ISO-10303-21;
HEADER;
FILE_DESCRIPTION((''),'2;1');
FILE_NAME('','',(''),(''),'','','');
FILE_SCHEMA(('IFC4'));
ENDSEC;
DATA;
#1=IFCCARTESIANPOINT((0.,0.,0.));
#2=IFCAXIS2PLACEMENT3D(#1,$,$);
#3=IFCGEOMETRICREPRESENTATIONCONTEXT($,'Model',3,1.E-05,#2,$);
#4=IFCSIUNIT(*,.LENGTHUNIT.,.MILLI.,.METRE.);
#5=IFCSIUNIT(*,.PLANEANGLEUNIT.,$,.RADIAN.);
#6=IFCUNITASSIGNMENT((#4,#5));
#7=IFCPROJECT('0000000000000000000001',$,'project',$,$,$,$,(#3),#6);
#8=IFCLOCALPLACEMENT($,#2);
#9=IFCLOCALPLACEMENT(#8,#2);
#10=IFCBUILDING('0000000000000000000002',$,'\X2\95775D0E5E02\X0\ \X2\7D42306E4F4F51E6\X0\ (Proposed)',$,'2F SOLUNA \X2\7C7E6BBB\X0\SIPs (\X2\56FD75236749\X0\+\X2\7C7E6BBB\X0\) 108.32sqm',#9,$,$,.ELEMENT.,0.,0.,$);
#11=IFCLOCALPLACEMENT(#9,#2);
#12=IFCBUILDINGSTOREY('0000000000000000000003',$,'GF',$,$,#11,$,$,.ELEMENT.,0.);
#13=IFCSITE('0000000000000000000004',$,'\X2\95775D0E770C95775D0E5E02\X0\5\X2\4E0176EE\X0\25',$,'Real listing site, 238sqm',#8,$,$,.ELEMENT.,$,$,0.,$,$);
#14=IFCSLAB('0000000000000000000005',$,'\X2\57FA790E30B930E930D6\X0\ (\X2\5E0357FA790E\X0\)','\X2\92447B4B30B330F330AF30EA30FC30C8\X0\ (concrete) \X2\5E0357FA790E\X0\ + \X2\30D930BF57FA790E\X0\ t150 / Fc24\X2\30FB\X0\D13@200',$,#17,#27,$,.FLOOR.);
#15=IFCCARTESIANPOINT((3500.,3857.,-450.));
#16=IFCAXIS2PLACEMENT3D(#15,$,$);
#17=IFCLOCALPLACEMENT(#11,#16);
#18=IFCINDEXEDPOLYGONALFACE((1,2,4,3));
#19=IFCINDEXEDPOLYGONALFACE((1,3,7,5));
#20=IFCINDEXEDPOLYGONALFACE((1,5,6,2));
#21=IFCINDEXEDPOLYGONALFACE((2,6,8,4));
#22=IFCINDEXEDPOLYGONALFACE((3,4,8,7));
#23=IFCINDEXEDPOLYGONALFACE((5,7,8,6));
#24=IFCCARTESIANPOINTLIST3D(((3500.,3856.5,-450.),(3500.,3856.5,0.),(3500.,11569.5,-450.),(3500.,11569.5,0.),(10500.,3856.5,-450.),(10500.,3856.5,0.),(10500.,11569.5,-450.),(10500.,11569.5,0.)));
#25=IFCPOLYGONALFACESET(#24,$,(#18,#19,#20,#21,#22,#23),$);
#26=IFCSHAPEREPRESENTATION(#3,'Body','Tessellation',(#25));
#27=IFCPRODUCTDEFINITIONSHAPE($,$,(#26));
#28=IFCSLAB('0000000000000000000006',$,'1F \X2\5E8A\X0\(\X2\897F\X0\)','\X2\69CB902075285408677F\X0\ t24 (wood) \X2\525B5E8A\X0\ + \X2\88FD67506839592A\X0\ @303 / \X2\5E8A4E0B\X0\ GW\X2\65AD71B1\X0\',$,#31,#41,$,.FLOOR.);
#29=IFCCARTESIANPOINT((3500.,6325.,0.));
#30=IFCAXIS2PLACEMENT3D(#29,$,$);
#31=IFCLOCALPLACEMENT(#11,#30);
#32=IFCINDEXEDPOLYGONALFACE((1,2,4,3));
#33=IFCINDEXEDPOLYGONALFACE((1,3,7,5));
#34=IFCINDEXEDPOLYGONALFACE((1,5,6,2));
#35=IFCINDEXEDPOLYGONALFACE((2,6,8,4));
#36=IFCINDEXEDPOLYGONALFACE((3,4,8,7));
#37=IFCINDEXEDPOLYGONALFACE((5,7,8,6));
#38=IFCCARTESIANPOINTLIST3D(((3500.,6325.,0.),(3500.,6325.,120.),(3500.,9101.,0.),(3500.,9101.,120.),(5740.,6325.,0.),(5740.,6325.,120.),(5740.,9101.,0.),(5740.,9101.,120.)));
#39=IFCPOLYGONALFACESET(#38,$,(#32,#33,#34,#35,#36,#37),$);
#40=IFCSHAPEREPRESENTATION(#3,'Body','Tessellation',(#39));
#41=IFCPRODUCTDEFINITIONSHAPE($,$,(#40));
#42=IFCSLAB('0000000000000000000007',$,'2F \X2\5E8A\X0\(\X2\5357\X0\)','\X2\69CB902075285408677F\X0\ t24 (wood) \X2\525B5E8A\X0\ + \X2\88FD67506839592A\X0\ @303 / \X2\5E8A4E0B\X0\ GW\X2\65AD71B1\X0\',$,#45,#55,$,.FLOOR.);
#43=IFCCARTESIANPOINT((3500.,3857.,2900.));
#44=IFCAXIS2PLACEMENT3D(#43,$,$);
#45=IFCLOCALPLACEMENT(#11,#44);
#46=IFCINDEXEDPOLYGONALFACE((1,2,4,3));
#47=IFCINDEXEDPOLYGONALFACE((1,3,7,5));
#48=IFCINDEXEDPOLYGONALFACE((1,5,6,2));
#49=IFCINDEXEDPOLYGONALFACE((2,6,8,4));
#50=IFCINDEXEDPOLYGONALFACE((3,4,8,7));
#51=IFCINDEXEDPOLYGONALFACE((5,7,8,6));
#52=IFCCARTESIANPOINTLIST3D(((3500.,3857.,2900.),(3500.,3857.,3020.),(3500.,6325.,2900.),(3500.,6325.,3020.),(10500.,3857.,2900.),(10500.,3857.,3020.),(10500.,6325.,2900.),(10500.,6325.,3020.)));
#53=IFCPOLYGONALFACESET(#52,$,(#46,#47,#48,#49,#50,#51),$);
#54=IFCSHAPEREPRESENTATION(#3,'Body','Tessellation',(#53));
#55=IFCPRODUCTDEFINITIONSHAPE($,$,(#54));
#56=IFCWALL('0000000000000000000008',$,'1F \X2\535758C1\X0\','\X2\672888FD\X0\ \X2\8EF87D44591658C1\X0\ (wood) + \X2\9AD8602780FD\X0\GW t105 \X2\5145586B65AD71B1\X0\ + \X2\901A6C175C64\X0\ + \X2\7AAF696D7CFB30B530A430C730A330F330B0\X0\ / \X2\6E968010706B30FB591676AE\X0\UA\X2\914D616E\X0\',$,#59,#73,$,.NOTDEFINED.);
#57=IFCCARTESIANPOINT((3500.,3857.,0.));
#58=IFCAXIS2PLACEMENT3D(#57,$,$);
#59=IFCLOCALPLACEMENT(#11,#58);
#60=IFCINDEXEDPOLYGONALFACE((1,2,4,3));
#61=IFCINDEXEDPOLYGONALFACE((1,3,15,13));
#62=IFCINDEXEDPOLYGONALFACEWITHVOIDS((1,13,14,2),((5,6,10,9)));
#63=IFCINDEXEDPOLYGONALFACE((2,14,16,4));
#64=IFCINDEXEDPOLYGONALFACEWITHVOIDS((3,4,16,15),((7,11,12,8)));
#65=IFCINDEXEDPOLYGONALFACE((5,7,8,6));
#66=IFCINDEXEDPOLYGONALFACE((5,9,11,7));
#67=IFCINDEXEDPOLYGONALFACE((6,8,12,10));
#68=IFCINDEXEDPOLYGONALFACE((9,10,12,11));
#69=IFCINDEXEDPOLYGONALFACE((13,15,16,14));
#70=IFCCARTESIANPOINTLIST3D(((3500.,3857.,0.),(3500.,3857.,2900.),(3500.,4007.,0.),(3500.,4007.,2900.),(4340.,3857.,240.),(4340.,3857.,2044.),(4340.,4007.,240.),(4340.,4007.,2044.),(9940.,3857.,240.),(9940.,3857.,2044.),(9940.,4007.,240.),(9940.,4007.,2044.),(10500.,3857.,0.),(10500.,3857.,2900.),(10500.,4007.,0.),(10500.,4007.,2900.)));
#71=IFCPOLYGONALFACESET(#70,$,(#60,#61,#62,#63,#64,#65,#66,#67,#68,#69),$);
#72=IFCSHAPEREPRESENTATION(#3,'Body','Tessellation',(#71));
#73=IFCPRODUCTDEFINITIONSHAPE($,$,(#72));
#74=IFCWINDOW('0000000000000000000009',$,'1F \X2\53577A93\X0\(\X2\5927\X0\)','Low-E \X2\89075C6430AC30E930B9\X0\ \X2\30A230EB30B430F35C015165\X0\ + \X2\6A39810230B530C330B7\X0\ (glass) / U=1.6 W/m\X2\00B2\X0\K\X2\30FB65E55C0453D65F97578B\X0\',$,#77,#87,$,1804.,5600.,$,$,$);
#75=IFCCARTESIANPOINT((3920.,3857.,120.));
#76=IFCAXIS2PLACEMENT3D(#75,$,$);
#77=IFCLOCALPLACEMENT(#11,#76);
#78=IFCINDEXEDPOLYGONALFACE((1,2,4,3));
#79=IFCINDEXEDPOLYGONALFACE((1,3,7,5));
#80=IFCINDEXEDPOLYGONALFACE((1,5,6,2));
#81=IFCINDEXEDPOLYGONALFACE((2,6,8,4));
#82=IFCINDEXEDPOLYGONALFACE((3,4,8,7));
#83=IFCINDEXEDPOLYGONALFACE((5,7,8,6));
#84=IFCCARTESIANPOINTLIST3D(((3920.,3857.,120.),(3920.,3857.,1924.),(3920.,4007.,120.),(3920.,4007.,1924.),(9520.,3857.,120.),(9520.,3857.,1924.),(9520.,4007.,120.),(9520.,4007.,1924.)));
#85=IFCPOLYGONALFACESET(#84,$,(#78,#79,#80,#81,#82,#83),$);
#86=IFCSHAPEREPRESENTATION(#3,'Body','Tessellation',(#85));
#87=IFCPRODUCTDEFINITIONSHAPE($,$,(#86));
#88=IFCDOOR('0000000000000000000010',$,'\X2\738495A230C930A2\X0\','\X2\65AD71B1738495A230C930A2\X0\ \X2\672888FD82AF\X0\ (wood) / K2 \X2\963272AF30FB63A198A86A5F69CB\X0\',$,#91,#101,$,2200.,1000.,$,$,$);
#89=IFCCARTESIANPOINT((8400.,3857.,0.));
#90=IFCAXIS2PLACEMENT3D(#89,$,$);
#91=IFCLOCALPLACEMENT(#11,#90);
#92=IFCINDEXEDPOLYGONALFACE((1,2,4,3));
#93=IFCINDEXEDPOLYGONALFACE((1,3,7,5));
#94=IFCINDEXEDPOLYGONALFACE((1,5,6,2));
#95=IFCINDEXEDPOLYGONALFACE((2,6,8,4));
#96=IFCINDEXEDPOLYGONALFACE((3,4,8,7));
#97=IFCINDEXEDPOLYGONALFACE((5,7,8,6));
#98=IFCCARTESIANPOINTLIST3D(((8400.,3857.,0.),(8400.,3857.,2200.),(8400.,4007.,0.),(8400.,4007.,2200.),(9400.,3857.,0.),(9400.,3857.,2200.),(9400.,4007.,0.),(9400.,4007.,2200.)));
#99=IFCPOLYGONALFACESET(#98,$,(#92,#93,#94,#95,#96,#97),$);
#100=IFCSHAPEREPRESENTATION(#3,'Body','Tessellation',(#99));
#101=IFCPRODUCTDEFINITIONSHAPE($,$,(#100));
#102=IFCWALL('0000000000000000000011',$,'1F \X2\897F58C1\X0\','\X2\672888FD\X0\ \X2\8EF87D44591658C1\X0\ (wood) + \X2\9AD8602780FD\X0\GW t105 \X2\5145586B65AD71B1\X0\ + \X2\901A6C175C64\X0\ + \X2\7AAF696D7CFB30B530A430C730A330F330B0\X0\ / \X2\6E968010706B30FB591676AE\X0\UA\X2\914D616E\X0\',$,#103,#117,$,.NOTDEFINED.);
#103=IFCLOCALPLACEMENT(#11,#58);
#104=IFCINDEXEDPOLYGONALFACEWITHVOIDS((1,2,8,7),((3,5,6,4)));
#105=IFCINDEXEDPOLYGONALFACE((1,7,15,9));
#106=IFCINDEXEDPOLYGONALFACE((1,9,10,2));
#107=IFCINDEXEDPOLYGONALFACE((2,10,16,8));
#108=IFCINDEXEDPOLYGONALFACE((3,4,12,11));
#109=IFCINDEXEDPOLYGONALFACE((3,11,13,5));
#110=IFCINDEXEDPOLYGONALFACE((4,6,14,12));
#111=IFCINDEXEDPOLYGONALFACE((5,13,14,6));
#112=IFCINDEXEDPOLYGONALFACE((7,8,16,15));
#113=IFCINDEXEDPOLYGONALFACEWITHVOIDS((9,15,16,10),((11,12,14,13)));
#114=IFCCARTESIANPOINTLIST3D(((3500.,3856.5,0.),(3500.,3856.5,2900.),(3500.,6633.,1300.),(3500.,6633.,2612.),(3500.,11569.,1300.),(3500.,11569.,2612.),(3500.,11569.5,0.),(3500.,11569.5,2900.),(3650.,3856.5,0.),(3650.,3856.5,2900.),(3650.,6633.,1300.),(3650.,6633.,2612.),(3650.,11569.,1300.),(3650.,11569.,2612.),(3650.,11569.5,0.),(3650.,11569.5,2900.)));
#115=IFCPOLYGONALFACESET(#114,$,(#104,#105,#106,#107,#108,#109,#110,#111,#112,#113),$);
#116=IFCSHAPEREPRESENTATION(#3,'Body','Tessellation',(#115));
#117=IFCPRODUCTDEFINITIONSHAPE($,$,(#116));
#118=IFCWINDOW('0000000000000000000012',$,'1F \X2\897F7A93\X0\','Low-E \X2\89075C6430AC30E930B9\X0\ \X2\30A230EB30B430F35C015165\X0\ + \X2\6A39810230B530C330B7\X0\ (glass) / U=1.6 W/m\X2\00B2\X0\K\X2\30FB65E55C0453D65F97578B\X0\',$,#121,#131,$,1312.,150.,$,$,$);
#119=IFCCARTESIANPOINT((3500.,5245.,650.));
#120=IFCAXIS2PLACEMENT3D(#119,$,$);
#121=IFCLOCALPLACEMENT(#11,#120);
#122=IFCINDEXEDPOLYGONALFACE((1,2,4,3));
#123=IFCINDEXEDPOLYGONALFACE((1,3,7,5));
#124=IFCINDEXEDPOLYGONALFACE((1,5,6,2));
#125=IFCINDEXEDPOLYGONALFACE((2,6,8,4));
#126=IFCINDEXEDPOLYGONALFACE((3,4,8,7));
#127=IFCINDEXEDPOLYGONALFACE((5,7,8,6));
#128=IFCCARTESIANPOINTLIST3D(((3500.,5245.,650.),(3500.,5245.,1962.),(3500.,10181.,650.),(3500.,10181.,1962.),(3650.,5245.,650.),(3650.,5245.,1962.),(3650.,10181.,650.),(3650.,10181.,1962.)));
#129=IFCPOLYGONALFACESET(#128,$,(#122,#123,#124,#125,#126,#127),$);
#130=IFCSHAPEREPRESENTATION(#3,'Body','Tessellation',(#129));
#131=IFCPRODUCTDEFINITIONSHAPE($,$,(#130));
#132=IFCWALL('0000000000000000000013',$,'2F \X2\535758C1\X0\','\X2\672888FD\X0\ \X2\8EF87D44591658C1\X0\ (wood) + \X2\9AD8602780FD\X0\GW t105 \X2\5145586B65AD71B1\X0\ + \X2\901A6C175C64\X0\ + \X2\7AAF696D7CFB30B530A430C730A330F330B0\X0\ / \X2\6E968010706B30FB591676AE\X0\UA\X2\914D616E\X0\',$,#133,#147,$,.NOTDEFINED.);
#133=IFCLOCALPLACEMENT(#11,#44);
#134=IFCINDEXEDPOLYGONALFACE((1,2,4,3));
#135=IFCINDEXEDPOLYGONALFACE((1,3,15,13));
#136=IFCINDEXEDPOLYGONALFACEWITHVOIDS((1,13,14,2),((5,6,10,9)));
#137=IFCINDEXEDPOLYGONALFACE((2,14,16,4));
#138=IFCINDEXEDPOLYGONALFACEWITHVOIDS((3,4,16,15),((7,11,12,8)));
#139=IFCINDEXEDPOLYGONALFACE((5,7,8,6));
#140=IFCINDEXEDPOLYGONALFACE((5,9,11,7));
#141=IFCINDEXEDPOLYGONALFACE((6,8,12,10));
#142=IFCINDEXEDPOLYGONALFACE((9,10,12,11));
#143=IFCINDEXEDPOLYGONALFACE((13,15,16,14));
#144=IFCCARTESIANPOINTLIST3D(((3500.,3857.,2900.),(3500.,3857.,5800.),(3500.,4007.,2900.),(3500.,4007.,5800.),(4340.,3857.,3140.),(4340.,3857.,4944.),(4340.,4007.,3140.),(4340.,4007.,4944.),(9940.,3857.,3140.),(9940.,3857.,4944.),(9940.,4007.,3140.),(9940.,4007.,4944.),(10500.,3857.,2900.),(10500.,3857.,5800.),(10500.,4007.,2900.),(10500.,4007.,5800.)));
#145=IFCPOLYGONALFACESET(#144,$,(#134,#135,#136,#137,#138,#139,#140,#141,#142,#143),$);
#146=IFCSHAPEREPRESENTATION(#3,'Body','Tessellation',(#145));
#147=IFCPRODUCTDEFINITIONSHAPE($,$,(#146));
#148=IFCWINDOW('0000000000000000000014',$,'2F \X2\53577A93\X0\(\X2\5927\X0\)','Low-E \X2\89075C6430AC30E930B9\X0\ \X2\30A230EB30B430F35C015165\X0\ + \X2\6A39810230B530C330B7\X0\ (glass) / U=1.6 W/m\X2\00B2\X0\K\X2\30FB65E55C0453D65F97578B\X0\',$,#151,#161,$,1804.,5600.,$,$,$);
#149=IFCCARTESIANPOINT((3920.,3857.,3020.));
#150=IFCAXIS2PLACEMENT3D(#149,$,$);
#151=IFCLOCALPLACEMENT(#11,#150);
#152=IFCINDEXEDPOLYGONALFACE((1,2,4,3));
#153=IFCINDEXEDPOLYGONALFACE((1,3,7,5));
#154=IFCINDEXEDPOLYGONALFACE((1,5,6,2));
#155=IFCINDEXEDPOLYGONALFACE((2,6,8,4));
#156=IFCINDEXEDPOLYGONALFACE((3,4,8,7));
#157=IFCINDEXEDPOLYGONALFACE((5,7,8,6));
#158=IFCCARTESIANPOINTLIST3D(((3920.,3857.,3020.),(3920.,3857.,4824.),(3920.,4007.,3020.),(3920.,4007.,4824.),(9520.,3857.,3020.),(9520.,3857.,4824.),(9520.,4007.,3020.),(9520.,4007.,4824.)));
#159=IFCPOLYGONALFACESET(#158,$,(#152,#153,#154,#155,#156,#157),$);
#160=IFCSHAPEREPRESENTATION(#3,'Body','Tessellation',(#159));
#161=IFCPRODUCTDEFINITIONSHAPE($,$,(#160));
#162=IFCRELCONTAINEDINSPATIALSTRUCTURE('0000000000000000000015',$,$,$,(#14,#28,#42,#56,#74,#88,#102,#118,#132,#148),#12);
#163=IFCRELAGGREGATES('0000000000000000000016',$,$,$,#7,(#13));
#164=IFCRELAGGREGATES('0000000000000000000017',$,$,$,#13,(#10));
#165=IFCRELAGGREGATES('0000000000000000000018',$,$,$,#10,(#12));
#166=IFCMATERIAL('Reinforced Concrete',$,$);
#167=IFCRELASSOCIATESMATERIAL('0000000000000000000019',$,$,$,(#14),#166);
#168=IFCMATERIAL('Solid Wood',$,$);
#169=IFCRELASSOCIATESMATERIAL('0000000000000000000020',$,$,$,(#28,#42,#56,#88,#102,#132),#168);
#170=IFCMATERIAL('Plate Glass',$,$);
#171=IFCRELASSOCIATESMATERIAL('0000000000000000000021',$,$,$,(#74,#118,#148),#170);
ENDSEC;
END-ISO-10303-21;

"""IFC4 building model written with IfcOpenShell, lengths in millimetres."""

from ifc_helpers import new_model, si_unit, frame, frame_2d, origin, place, context, project, spatial, rectangle, extrude, material, element, fill, save


model = new_model("IFC4")

# Units and contexts
model_context = context("Model", 3, precision=1e-05, world=origin())
ifc_project = project(units=[si_unit("LENGTHUNIT", "METRE", prefix="MILLI"), si_unit("PLANEANGLEUNIT", "RADIAN")], contexts=[model_context])

# Site, building, storey
site_placement = place(None, origin())
site = spatial("IfcSite", under=ifc_project, at=site_placement, Name="長崎県長崎市5丁目25", ObjectType="Real listing site, 238sqm", CompositionType="ELEMENT", RefElevation=0.0)
building_placement = place(site_placement, origin())
building = spatial("IfcBuilding", under=site, at=building_placement, Name="長崎市 終の住処 (Proposed)", ObjectType="2F SOLUNA 籾殻SIPs (国産杉+籾殻) 108.32sqm", CompositionType="ELEMENT", ElevationOfRefHeight=0.0, ElevationOfTerrain=0.0)
storey_placement = place(building_placement, origin())
storey = spatial("IfcBuildingStorey", under=building, at=storey_placement, Name="GF", CompositionType="ELEMENT", Elevation=0.0)

# Slabs
ifc_material_1 = material(Name="Reinforced Concrete")
slab_1_placement = place(storey_placement, frame((3500.0, 3857.0, -450.0)))
element("IfcSlab", 1, at=slab_1_placement, inside=storey, material=ifc_material_1, Name="基礎スラブ (布基礎)", Description="鉄筋コンクリート (concrete) 布基礎 + ベタ基礎 t150 / Fc24・D13@200", PredefinedType="FLOOR", context=model_context, shape_type="SweptSolid", body=[
    extrude(rectangle(XDim=7000.0, YDim=7713.0, at=frame_2d((3500.0, 3856.0))), frame((3500.0, 3857.0, -450.0)), (0.0, 0.0, 1.0), 450.0),
])
ifc_material_2 = material(Name="Solid Wood")
slab_2_placement = place(storey_placement, frame((3500.0, 6325.0, 0.0)))
element("IfcSlab", 2, at=slab_2_placement, inside=storey, material=ifc_material_2, Name="1F 床(西)", Description="構造用合板 t24 (wood) 剛床 + 製材根太 @303 / 床下 GW断熱", PredefinedType="FLOOR", context=model_context, shape_type="SweptSolid", body=[
    extrude(rectangle(XDim=2240.0, YDim=2776.0, at=frame_2d((1120.0, 1388.0))), frame((3500.0, 6325.0, 0.0)), (0.0, 0.0, 1.0), 120.0),
])
slab_3_placement = place(storey_placement, frame((3500.0, 3857.0, 2900.0)))
element("IfcSlab", 3, at=slab_3_placement, inside=storey, material=ifc_material_2, Name="2F 床(南)", Description="構造用合板 t24 (wood) 剛床 + 製材根太 @303 / 床下 GW断熱", PredefinedType="FLOOR", context=model_context, shape_type="SweptSolid", body=[
    extrude(rectangle(XDim=7000.0, YDim=2468.0, at=frame_2d((3500.0, 1234.0))), frame((3500.0, 3857.0, 2900.0)), (0.0, 0.0, 1.0), 120.0),
])

# Wall, openings, window, door
wall_1_placement = place(storey_placement, frame((3500.0, 3857.0, 0.0)))
wall_1 = element("IfcWall", 4, at=wall_1_placement, inside=storey, material=ifc_material_2, Name="1F 南壁", Description="木製 軸組外壁 (wood) + 高性能GW t105 充填断熱 + 通気層 + 窯業系サイディング / 準耐火・外皮UA配慮", PredefinedType="NOTDEFINED", context=model_context, shape_type="SweptSolid", body=[
    extrude(rectangle(XDim=7000.0, YDim=150.0, at=frame_2d((3500.0, 75.0))), frame((3500.0, 3857.0, 0.0)), (0.0, 0.0, 1.0), 2900.0),
])
opening_1_placement = place(storey_placement, frame((3920.0, 3857.0, 120.0)))
opening_1 = element("IfcOpeningElement", 5, at=opening_1_placement, cuts=wall_1, PredefinedType="NOTDEFINED", context=model_context, shape_type="SweptSolid", body=[
    extrude(rectangle(XDim=5600.0, YDim=150.0, at=frame_2d((2800.0, 75.0))), frame((3920.0, 3857.0, 120.0)), (0.0, 0.0, 1.0), 1804.0),
])
opening_2_placement = place(storey_placement, frame((8400.0, 3857.0, 0.0)))
opening_2 = element("IfcOpeningElement", 6, at=opening_2_placement, cuts=wall_1, PredefinedType="NOTDEFINED", context=model_context, shape_type="SweptSolid", body=[
    extrude(rectangle(XDim=1000.0, YDim=150.0, at=frame_2d((500.0, 75.0))), frame((8400.0, 3857.0, 0.0)), (0.0, 0.0, 1.0), 2200.0),
])
ifc_material_3 = material(Name="Plate Glass")
window_1_placement = place(storey_placement, frame((3920.0, 3857.0, 120.0)))
window_1 = element("IfcWindow", 7, at=window_1_placement, inside=storey, material=ifc_material_3, Name="1F 南窓(大)", Description="Low-E 複層ガラス アルゴン封入 + 樹脂サッシ (glass) / U=1.6 W/m²K・日射取得型", OverallHeight=1804.0, OverallWidth=5600.0, context=model_context, shape_type="SweptSolid", body=[
    extrude(rectangle(XDim=5600.0, YDim=150.0, at=frame_2d((2800.0, 75.0))), frame((3920.0, 3857.0, 120.0)), (0.0, 0.0, 1.0), 1804.0),
])
fill(opening_1, window_1)
door_placement = place(storey_placement, frame((8400.0, 3857.0, 0.0)))
door = element("IfcDoor", 8, at=door_placement, inside=storey, material=ifc_material_2, Name="玄関ドア", Description="断熱玄関ドア 木製芯 (wood) / K2 防犯・採風機構", OverallHeight=2200.0, OverallWidth=1000.0, context=model_context, shape_type="SweptSolid", body=[
    extrude(rectangle(XDim=1000.0, YDim=150.0, at=frame_2d((500.0, 75.0))), frame((8400.0, 3857.0, 0.0)), (0.0, 0.0, 1.0), 2200.0),
])
fill(opening_2, door)

# Walls, openings, windows
wall_2_placement = place(storey_placement, frame((3500.0, 3857.0, 0.0)))
wall_2 = element("IfcWall", 9, at=wall_2_placement, inside=storey, material=ifc_material_2, Name="1F 西壁", Description="木製 軸組外壁 (wood) + 高性能GW t105 充填断熱 + 通気層 + 窯業系サイディング / 準耐火・外皮UA配慮", PredefinedType="NOTDEFINED", context=model_context, shape_type="SweptSolid", body=[
    extrude(rectangle(XDim=150.0, YDim=7713.0, at=frame_2d((75.0, 3856.0))), frame((3500.0, 3857.0, 0.0)), (0.0, 0.0, 1.0), 2900.0),
])
opening_3_placement = place(storey_placement, frame((3500.0, 5245.0, 650.0)))
opening_3 = element("IfcOpeningElement", 10, at=opening_3_placement, cuts=wall_2, PredefinedType="NOTDEFINED", context=model_context, shape_type="SweptSolid", body=[
    extrude(rectangle(XDim=150.0, YDim=4936.0, at=frame_2d((75.0, 2468.0))), frame((3500.0, 5245.0, 650.0)), (0.0, 0.0, 1.0), 1312.0),
])
window_2_placement = place(storey_placement, frame((3500.0, 5245.0, 650.0)))
window_2 = element("IfcWindow", 11, at=window_2_placement, inside=storey, material=ifc_material_3, Name="1F 西窓", Description="Low-E 複層ガラス アルゴン封入 + 樹脂サッシ (glass) / U=1.6 W/m²K・日射取得型", OverallHeight=1312.0, OverallWidth=150.0, context=model_context, shape_type="SweptSolid", body=[
    extrude(rectangle(XDim=150.0, YDim=4936.0, at=frame_2d((75.0, 2468.0))), frame((3500.0, 5245.0, 650.0)), (0.0, 0.0, 1.0), 1312.0),
])
fill(opening_3, window_2)
wall_3_placement = place(storey_placement, frame((3500.0, 3857.0, 2900.0)))
wall_3 = element("IfcWall", 12, at=wall_3_placement, inside=storey, material=ifc_material_2, Name="2F 南壁", Description="木製 軸組外壁 (wood) + 高性能GW t105 充填断熱 + 通気層 + 窯業系サイディング / 準耐火・外皮UA配慮", PredefinedType="NOTDEFINED", context=model_context, shape_type="SweptSolid", body=[
    extrude(rectangle(XDim=7000.0, YDim=150.0, at=frame_2d((3500.0, 75.0))), frame((3500.0, 3857.0, 2900.0)), (0.0, 0.0, 1.0), 2900.0),
])
opening_4_placement = place(storey_placement, frame((3920.0, 3857.0, 3020.0)))
opening_4 = element("IfcOpeningElement", 13, at=opening_4_placement, cuts=wall_3, PredefinedType="NOTDEFINED", context=model_context, shape_type="SweptSolid", body=[
    extrude(rectangle(XDim=5600.0, YDim=150.0, at=frame_2d((2800.0, 75.0))), frame((3920.0, 3857.0, 3020.0)), (0.0, 0.0, 1.0), 1804.0),
])
window_3_placement = place(storey_placement, frame((3920.0, 3857.0, 3020.0)))
window_3 = element("IfcWindow", 14, at=window_3_placement, inside=storey, material=ifc_material_3, Name="2F 南窓(大)", Description="Low-E 複層ガラス アルゴン封入 + 樹脂サッシ (glass) / U=1.6 W/m²K・日射取得型", OverallHeight=1804.0, OverallWidth=5600.0, context=model_context, shape_type="SweptSolid", body=[
    extrude(rectangle(XDim=5600.0, YDim=150.0, at=frame_2d((2800.0, 75.0))), frame((3920.0, 3857.0, 3020.0)), (0.0, 0.0, 1.0), 1804.0),
])
fill(opening_4, window_3)

save(model, "model.ifc")
